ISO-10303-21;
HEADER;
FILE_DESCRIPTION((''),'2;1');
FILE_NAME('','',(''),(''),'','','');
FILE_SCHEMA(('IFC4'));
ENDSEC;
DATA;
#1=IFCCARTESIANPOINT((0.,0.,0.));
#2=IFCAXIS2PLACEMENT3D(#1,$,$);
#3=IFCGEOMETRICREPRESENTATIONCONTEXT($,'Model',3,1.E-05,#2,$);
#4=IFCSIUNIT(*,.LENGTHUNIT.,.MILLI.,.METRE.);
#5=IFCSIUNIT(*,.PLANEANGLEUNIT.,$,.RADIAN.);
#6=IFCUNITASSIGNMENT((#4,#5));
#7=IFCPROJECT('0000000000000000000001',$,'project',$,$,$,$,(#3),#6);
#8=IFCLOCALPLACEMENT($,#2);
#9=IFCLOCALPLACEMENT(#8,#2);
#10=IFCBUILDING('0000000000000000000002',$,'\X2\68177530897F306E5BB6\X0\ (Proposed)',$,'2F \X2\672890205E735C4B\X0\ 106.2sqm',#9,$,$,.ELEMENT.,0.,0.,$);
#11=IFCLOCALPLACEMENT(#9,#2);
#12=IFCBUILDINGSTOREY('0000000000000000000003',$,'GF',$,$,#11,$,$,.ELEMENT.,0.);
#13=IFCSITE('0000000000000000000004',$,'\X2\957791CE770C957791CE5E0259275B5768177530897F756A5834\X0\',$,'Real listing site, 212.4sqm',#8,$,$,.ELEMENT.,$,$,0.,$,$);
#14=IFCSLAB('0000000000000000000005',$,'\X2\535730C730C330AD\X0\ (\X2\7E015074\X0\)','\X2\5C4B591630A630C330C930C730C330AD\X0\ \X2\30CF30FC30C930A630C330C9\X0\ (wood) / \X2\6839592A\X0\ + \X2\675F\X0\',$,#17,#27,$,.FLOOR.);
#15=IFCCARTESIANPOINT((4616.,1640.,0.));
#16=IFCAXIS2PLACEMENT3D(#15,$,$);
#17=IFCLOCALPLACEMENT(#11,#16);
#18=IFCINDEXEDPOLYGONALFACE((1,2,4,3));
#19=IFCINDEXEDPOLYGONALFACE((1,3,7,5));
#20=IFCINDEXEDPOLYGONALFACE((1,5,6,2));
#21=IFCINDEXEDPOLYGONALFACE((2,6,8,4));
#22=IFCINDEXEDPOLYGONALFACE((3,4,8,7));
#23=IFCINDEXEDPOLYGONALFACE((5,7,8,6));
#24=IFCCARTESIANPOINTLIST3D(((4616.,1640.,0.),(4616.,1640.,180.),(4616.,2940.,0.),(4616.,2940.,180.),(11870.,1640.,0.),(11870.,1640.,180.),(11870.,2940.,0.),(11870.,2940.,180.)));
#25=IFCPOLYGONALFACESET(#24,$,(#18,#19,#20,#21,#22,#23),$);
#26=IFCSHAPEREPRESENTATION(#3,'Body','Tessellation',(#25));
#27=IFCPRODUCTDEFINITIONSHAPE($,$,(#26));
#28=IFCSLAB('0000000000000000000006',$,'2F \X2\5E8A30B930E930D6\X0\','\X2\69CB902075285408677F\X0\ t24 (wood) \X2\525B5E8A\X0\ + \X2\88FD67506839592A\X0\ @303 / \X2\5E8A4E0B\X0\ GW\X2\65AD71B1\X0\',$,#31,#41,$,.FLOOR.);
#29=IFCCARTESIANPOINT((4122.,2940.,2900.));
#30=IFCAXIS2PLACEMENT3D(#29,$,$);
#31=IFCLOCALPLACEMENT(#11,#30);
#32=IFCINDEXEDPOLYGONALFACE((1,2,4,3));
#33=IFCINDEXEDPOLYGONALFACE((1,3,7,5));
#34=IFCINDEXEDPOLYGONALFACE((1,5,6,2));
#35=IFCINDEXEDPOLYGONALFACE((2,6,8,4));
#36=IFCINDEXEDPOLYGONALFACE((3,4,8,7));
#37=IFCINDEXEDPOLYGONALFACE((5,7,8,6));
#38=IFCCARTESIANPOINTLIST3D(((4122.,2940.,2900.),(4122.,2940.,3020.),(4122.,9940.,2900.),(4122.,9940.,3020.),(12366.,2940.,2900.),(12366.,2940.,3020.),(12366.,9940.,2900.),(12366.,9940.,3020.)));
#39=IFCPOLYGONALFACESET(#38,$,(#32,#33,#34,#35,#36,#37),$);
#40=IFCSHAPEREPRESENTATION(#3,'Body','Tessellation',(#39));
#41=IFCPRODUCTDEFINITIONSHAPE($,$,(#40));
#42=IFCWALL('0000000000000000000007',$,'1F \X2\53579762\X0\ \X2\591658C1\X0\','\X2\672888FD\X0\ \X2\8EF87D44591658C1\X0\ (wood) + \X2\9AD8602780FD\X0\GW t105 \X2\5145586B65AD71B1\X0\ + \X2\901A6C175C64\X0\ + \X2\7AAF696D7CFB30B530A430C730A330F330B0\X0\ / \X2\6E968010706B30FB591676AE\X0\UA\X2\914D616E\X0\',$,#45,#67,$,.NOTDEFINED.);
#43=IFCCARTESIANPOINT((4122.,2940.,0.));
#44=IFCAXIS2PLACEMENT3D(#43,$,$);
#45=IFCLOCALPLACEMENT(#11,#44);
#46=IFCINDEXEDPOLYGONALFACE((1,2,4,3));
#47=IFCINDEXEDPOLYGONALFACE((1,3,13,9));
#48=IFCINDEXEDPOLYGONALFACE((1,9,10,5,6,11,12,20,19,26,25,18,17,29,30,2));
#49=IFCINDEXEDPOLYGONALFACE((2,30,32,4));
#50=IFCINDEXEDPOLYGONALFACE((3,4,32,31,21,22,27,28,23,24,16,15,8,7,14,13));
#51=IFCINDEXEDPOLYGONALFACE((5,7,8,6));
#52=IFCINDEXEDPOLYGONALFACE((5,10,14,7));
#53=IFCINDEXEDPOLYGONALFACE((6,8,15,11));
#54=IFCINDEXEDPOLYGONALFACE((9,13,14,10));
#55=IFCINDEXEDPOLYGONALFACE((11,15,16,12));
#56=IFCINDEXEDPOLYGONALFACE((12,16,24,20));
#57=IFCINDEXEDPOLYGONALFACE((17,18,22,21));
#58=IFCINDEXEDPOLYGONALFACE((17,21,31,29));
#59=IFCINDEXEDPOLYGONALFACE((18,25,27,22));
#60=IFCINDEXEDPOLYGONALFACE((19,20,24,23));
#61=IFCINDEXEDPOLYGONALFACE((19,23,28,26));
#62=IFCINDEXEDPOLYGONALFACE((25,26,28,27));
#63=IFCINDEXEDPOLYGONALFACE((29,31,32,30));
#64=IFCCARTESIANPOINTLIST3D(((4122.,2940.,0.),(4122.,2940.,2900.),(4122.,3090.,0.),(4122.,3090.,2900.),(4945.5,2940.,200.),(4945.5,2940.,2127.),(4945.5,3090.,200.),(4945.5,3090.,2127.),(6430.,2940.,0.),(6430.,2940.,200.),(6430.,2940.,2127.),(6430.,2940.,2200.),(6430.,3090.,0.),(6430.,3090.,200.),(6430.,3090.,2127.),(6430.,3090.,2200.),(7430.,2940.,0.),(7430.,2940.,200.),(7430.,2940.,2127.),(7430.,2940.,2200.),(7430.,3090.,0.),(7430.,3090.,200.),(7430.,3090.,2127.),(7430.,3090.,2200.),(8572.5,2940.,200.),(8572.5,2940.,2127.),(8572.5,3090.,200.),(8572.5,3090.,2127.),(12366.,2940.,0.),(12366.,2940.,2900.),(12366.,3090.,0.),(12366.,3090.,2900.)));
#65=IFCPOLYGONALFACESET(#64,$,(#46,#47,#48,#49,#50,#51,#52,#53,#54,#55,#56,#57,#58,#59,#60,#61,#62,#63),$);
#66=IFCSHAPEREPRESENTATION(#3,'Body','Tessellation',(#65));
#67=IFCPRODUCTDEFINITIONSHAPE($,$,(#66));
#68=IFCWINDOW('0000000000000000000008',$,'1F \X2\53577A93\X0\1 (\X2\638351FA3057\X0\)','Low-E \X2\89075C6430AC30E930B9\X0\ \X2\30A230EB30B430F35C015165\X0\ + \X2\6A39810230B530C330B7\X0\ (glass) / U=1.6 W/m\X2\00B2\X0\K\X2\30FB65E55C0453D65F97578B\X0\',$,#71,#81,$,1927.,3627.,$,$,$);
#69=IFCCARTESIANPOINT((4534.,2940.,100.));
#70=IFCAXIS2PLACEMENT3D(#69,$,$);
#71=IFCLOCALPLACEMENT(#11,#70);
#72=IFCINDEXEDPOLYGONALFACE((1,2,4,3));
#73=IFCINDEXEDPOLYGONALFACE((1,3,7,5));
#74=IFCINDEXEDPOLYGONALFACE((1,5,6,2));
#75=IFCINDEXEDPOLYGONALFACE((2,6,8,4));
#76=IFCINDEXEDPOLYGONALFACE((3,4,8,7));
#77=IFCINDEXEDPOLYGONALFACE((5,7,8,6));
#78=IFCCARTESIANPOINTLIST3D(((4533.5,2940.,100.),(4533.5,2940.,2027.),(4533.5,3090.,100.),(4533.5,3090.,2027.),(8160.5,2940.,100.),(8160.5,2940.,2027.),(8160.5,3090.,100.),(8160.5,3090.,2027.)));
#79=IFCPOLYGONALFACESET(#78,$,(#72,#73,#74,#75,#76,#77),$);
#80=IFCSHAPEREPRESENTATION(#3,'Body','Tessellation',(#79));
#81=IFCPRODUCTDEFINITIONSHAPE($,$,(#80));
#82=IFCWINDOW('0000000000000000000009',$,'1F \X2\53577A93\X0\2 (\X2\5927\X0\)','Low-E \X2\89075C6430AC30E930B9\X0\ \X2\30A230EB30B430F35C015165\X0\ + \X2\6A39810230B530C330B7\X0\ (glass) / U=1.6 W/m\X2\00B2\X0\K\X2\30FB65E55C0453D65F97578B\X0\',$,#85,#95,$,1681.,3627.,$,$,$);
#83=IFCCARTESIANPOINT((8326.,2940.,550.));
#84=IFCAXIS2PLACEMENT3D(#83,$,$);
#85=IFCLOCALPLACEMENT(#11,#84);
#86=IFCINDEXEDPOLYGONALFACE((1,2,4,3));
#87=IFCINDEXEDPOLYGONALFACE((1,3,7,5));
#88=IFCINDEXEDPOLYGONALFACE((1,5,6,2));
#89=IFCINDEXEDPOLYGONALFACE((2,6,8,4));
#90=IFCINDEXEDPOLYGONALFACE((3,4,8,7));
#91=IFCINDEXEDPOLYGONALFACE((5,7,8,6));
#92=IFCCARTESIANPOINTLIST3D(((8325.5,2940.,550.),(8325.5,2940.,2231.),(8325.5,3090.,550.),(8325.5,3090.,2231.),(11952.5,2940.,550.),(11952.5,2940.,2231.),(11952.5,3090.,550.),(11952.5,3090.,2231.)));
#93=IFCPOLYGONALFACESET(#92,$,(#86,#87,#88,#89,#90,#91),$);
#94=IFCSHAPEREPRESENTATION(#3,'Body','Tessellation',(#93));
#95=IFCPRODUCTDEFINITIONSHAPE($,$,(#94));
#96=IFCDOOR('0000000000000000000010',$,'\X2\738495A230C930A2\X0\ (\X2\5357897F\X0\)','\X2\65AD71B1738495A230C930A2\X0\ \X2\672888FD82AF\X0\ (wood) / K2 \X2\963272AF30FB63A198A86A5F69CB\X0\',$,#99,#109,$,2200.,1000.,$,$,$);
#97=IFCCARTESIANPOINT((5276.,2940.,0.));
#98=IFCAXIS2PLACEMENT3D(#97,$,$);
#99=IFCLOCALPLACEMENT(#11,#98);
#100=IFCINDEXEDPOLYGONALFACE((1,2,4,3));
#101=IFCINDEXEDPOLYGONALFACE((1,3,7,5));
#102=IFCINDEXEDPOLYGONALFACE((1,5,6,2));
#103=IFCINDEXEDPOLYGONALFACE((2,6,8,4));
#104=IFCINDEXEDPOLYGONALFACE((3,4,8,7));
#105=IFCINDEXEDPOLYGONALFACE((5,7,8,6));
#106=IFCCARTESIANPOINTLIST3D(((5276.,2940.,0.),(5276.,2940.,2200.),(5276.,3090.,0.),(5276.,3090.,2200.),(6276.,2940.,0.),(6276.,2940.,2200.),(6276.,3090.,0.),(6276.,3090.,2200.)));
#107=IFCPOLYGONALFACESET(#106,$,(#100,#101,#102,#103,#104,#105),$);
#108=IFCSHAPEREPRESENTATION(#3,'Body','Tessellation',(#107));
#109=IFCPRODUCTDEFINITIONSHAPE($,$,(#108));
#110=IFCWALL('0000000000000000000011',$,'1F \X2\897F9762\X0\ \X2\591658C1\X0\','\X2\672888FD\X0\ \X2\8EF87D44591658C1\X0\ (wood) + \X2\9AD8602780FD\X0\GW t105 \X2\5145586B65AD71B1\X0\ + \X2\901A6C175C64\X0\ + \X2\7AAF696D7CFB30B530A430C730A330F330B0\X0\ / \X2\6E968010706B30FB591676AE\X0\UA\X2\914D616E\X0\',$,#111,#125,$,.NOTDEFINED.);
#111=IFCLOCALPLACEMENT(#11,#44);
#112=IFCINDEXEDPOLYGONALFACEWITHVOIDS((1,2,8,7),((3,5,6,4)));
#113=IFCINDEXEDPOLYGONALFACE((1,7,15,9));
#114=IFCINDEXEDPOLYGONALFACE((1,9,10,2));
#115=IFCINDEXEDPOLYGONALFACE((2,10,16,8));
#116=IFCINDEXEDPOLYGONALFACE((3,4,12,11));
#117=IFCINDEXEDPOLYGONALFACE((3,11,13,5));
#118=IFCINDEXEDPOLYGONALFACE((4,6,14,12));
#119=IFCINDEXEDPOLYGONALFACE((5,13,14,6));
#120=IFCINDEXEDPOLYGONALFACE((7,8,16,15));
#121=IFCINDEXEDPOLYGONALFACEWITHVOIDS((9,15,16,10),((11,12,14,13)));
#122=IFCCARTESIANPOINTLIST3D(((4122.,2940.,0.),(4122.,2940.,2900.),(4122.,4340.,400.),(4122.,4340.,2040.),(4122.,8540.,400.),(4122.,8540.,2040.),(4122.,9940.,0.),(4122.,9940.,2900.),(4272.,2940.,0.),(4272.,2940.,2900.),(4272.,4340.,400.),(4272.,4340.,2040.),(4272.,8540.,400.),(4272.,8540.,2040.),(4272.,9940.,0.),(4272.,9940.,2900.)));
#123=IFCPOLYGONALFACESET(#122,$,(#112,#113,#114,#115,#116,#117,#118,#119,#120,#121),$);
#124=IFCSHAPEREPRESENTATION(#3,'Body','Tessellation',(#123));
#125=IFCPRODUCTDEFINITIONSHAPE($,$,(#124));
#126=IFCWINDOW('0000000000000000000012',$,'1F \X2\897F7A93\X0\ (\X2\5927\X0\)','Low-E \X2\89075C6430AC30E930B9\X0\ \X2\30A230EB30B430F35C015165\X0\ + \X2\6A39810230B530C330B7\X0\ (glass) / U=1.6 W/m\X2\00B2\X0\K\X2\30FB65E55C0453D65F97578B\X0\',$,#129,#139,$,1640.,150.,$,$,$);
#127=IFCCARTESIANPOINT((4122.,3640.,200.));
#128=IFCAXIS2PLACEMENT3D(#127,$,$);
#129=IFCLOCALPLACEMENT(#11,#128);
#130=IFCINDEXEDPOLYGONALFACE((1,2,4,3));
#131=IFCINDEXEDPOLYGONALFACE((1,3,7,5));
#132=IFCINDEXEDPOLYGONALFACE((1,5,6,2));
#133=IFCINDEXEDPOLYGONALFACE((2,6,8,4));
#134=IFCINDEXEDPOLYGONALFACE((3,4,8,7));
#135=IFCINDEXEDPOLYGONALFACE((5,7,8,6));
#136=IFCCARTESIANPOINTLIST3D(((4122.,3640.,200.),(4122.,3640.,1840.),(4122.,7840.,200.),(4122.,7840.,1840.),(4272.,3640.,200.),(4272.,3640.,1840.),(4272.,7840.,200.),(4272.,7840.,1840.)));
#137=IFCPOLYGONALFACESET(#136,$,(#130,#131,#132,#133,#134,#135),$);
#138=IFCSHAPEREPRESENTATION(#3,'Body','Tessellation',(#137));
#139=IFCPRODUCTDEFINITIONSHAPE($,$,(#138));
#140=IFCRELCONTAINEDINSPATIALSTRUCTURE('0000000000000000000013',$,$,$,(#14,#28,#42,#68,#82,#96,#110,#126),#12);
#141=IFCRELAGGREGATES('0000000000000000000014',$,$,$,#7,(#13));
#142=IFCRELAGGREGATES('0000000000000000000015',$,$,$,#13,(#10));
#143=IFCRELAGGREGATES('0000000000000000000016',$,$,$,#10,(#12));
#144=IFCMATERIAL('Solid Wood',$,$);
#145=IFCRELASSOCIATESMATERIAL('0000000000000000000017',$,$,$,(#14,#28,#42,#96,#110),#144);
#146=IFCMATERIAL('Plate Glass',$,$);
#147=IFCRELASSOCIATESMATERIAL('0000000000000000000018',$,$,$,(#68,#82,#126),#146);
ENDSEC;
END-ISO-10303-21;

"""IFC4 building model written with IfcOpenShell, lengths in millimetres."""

from ifc_helpers import new_model, si_unit, frame, frame_2d, origin, place, context, project, spatial, rectangle, extrude, material, element, fill, save


model = new_model("IFC4")

# Units and contexts
model_context = context("Model", 3, precision=1e-05, world=origin())
ifc_project = project(units=[si_unit("LENGTHUNIT", "METRE", prefix="MILLI"), si_unit("PLANEANGLEUNIT", "RADIAN")], contexts=[model_context])

# Site, building, storey
site_placement = place(None, origin())
site = spatial("IfcSite", under=ifc_project, at=site_placement, Name="長野県長野市大字栗田西番場", ObjectType="Real listing site, 212.4sqm", CompositionType="ELEMENT", RefElevation=0.0)
building_placement = place(site_placement, origin())
building = spatial("IfcBuilding", under=site, at=building_placement, Name="栗田西の家 (Proposed)", ObjectType="2F 木造平屋 106.2sqm", CompositionType="ELEMENT", ElevationOfRefHeight=0.0, ElevationOfTerrain=0.0)
storey_placement = place(building_placement, origin())
storey = spatial("IfcBuildingStorey", under=building, at=storey_placement, Name="GF", CompositionType="ELEMENT", Elevation=0.0)

# Slabs
ifc_material_1 = material(Name="Solid Wood")
slab_1_placement = place(storey_placement, frame((4616.0, 1640.0, 0.0)))
element("IfcSlab", 1, at=slab_1_placement, inside=storey, material=ifc_material_1, Name="南デッキ (縁側)", Description="屋外ウッドデッキ ハードウッド (wood) / 根太 + 束", PredefinedType="FLOOR", context=model_context, shape_type="SweptSolid", body=[
    extrude(rectangle(XDim=7254.0, YDim=1300.0, at=frame_2d((3627.0, 650.0))), frame((4616.0, 1640.0, 0.0)), (0.0, 0.0, 1.0), 180.0),
])
slab_2_placement = place(storey_placement, frame((4122.0, 2940.0, 2900.0)))
element("IfcSlab", 2, at=slab_2_placement, inside=storey, material=ifc_material_1, Name="2F 床スラブ", Description="構造用合板 t24 (wood) 剛床 + 製材根太 @303 / 床下 GW断熱", PredefinedType="FLOOR", context=model_context, shape_type="SweptSolid", body=[
    extrude(rectangle(XDim=8244.0, YDim=7000.0, at=frame_2d((4122.0, 3500.0))), frame((4122.0, 2940.0, 2900.0)), (0.0, 0.0, 1.0), 120.0),
])

# Wall, openings, windows, door
wall_1_placement = place(storey_placement, frame((4122.0, 2940.0, 0.0)))
wall_1 = element("IfcWall", 3, at=wall_1_placement, inside=storey, material=ifc_material_1, Name="1F 南面 外壁", Description="木製 軸組外壁 (wood) + 高性能GW t105 充填断熱 + 通気層 + 窯業系サイディング / 準耐火・外皮UA配慮", PredefinedType="NOTDEFINED", context=model_context, shape_type="SweptSolid", body=[
    extrude(rectangle(XDim=8244.0, YDim=150.0, at=frame_2d((4122.0, 75.0))), frame((4122.0, 2940.0, 0.0)), (0.0, 0.0, 1.0), 2900.0),
])
opening_1_placement = place(storey_placement, frame((4534.0, 2940.0, 100.0)))
opening_1 = element("IfcOpeningElement", 4, at=opening_1_placement, cuts=wall_1, PredefinedType="NOTDEFINED", context=model_context, shape_type="SweptSolid", body=[
    extrude(rectangle(XDim=3627.0, YDim=150.0, at=frame_2d((1813.0, 75.0))), frame((4534.0, 2940.0, 100.0)), (0.0, 0.0, 1.0), 1927.0),
])
opening_2_placement = place(storey_placement, frame((8326.0, 2940.0, 550.0)))
opening_2 = element("IfcOpeningElement", 5, at=opening_2_placement, cuts=wall_1, PredefinedType="NOTDEFINED", context=model_context, shape_type="SweptSolid", body=[
    extrude(rectangle(XDim=3627.0, YDim=150.0, at=frame_2d((1813.0, 75.0))), frame((8326.0, 2940.0, 550.0)), (0.0, 0.0, 1.0), 1681.0),
])
opening_3_placement = place(storey_placement, frame((5276.0, 2940.0, 0.0)))
opening_3 = element("IfcOpeningElement", 6, at=opening_3_placement, cuts=wall_1, PredefinedType="NOTDEFINED", context=model_context, shape_type="SweptSolid", body=[
    extrude(rectangle(XDim=1000.0, YDim=150.0, at=frame_2d((500.0, 75.0))), frame((5276.0, 2940.0, 0.0)), (0.0, 0.0, 1.0), 2200.0),
])
ifc_material_2 = material(Name="Plate Glass")
window_1_placement = place(storey_placement, frame((4534.0, 2940.0, 100.0)))
window_1 = element("IfcWindow", 7, at=window_1_placement, inside=storey, material=ifc_material_2, Name="1F 南窓1 (掃出し)", Description="Low-E 複層ガラス アルゴン封入 + 樹脂サッシ (glass) / U=1.6 W/m²K・日射取得型", OverallHeight=1927.0, OverallWidth=3627.0, context=model_context, shape_type="SweptSolid", body=[
    extrude(rectangle(XDim=3627.0, YDim=150.0, at=frame_2d((1813.0, 75.0))), frame((4534.0, 2940.0, 100.0)), (0.0, 0.0, 1.0), 1927.0),
])
fill(opening_1, window_1)
window_2_placement = place(storey_placement, frame((8326.0, 2940.0, 550.0)))
window_2 = element("IfcWindow", 8, at=window_2_placement, inside=storey, material=ifc_material_2, Name="1F 南窓2 (大)", Description="Low-E 複層ガラス アルゴン封入 + 樹脂サッシ (glass) / U=1.6 W/m²K・日射取得型", OverallHeight=1681.0, OverallWidth=3627.0, context=model_context, shape_type="SweptSolid", body=[
    extrude(rectangle(XDim=3627.0, YDim=150.0, at=frame_2d((1813.0, 75.0))), frame((8326.0, 2940.0, 550.0)), (0.0, 0.0, 1.0), 1681.0),
])
fill(opening_2, window_2)
door_placement = place(storey_placement, frame((5276.0, 2940.0, 0.0)))
door = element("IfcDoor", 9, at=door_placement, inside=storey, material=ifc_material_1, Name="玄関ドア (南西)", Description="断熱玄関ドア 木製芯 (wood) / K2 防犯・採風機構", OverallHeight=2200.0, OverallWidth=1000.0, context=model_context, shape_type="SweptSolid", body=[
    extrude(rectangle(XDim=1000.0, YDim=150.0, at=frame_2d((500.0, 75.0))), frame((5276.0, 2940.0, 0.0)), (0.0, 0.0, 1.0), 2200.0),
])
fill(opening_3, door)

# Wall, opening, window
wall_2_placement = place(storey_placement, frame((4122.0, 2940.0, 0.0)))
wall_2 = element("IfcWall", 10, at=wall_2_placement, inside=storey, material=ifc_material_1, Name="1F 西面 外壁", Description="木製 軸組外壁 (wood) + 高性能GW t105 充填断熱 + 通気層 + 窯業系サイディング / 準耐火・外皮UA配慮", PredefinedType="NOTDEFINED", context=model_context, shape_type="SweptSolid", body=[
    extrude(rectangle(XDim=150.0, YDim=7000.0, at=frame_2d((75.0, 3500.0))), frame((4122.0, 2940.0, 0.0)), (0.0, 0.0, 1.0), 2900.0),
])
opening_4_placement = place(storey_placement, frame((4122.0, 3640.0, 200.0)))
opening_4 = element("IfcOpeningElement", 11, at=opening_4_placement, cuts=wall_2, PredefinedType="NOTDEFINED", context=model_context, shape_type="SweptSolid", body=[
    extrude(rectangle(XDim=150.0, YDim=4200.0, at=frame_2d((75.0, 2100.0))), frame((4122.0, 3640.0, 200.0)), (0.0, 0.0, 1.0), 1640.0),
])
window_3_placement = place(storey_placement, frame((4122.0, 3640.0, 200.0)))
window_3 = element("IfcWindow", 12, at=window_3_placement, inside=storey, material=ifc_material_2, Name="1F 西窓 (大)", Description="Low-E 複層ガラス アルゴン封入 + 樹脂サッシ (glass) / U=1.6 W/m²K・日射取得型", OverallHeight=1640.0, OverallWidth=150.0, context=model_context, shape_type="SweptSolid", body=[
    extrude(rectangle(XDim=150.0, YDim=4200.0, at=frame_2d((75.0, 2100.0))), frame((4122.0, 3640.0, 200.0)), (0.0, 0.0, 1.0), 1640.0),
])
fill(opening_4, window_3)

save(model, "model.ifc")
